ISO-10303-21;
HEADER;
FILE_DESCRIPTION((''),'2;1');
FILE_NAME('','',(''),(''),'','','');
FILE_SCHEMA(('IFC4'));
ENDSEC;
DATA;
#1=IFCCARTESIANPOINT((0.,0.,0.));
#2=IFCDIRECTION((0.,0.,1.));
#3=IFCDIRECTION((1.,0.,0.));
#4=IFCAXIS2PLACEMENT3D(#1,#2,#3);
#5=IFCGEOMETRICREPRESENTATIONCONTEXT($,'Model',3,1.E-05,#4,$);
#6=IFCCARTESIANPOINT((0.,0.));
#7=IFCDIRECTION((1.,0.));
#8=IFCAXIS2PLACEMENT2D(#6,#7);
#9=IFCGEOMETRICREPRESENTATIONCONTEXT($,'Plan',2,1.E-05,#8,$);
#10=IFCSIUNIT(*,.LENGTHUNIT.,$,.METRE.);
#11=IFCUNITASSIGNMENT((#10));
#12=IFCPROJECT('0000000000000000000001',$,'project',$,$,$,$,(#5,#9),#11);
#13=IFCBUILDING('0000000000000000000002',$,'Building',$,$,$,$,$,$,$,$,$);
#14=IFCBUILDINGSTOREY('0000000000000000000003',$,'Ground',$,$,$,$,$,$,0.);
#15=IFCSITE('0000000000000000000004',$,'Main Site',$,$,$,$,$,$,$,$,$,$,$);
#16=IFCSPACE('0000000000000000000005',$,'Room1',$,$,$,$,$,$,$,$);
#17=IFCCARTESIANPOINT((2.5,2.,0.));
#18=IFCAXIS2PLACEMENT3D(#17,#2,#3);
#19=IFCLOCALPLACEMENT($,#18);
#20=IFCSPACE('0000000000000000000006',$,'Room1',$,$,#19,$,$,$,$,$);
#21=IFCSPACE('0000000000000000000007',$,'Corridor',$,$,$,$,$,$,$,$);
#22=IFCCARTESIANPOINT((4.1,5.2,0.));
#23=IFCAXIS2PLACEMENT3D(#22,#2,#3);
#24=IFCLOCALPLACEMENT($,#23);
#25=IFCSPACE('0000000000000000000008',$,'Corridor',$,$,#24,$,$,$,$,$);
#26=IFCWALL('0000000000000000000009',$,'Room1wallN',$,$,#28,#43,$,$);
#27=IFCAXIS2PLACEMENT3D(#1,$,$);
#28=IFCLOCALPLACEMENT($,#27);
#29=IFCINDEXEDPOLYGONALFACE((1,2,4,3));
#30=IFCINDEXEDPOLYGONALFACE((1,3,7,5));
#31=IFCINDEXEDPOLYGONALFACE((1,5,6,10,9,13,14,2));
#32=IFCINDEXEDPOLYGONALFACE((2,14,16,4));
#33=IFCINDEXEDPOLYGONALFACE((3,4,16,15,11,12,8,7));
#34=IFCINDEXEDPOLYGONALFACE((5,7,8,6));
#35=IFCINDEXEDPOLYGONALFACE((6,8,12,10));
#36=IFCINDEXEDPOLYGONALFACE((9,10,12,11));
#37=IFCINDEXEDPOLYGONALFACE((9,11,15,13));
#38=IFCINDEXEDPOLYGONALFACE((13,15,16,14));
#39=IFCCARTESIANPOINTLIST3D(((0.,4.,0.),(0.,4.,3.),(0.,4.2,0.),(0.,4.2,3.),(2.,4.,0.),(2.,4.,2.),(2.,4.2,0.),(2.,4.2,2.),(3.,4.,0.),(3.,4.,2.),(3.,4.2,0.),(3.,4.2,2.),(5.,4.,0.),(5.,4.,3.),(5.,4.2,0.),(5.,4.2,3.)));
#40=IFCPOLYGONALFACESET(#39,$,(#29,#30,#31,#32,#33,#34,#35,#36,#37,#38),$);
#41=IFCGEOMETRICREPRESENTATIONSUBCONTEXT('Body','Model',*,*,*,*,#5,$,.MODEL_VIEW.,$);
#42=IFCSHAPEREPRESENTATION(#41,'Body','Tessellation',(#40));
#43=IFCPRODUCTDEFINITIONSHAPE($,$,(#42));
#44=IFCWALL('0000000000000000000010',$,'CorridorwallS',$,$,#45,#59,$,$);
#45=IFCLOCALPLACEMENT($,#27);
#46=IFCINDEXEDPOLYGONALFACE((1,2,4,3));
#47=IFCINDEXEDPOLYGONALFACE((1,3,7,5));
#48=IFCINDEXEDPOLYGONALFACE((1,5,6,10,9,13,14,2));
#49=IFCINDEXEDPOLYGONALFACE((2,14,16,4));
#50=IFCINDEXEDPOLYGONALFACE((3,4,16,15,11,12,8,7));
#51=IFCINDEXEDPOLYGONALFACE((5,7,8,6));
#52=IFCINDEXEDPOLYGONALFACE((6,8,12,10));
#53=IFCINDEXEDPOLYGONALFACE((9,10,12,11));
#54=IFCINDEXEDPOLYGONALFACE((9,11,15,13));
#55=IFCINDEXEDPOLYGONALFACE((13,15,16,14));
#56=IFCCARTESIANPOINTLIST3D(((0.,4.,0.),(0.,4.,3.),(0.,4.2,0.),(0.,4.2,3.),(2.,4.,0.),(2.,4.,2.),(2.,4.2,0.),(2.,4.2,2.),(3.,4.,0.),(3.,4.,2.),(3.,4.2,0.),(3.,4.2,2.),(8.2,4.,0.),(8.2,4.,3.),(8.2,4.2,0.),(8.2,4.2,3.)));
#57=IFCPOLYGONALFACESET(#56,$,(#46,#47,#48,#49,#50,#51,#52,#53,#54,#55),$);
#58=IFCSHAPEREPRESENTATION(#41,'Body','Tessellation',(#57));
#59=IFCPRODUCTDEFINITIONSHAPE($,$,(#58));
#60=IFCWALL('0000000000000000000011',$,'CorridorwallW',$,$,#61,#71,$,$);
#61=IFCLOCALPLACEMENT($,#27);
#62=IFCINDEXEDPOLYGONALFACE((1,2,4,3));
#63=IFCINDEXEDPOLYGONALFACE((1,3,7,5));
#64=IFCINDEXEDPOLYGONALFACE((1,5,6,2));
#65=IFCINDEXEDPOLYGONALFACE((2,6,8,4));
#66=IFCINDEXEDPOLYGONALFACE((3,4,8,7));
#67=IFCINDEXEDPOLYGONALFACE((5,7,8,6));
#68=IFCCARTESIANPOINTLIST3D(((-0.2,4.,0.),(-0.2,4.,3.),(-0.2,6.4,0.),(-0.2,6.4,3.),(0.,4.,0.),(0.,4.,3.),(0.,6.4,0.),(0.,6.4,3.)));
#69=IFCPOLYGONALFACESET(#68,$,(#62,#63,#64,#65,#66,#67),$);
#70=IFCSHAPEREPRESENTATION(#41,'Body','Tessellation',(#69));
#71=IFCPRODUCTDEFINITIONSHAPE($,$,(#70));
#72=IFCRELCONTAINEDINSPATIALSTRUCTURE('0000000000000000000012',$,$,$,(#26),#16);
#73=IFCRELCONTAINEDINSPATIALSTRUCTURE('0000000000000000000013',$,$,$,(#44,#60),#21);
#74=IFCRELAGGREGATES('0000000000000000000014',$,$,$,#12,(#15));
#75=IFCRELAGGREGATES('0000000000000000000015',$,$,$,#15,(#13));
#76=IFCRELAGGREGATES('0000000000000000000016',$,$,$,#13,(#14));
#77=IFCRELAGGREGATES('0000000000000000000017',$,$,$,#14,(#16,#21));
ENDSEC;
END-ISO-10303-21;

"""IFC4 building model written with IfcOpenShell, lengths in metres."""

from ifc_helpers import new_model, si_unit, frame, origin_with_axes, origin_2d_with_axis, place, context, subcontext, project, spatial, indexed_curve, outline, extrude, element, save


model = new_model("IFC4")

# Units and contexts
model_context = context("Model", 3, precision=1e-05, world=origin_with_axes())
plan_context = context("Plan", 2, precision=1e-05, world=origin_2d_with_axis())
body_context = subcontext(model_context, "Body", "Model", "MODEL_VIEW")
ifc_project = project(units=[si_unit("LENGTHUNIT", "METRE")], contexts=[model_context, plan_context])

# Site, building, storey, space
site = spatial("IfcSite", under=ifc_project, Name="Main Site")
building = spatial("IfcBuilding", under=site, Name="Building")
storey = spatial("IfcBuildingStorey", under=building, Name="Ground", Elevation=0.0)
space_1 = spatial("IfcSpace", under=storey, Name="Room1")

# Wall
wall_1_placement = place(None, frame((0.0, 4.0, 0.0), z_axis=(0.0, 0.0, 1.0), x_axis=(1.0, 0.0, 0.0)))
wall_1 = element("IfcWall", 1, at=wall_1_placement, inside=space_1, Name="Room1wallN", context=body_context, shape_type="SweptSolid", body=[
    extrude(outline(indexed_curve([(0.0, 0.0), (0.0, 0.2), (5.0, 0.2), (5.0, 0.0), (0.0, 0.0)], self_intersect=False)), origin_with_axes(), (0.0, 0.0, 1.0), 3.0),
])

# Shared definitions
space_2_placement = place(None, frame((2.5, 2.0, 0.0), z_axis=(0.0, 0.0, 1.0), x_axis=(1.0, 0.0, 0.0)))
space_2 = spatial("IfcSpace", at=space_2_placement, Name="Room1")

# Opening
opening_1_placement = place(wall_1_placement, frame((2.0, 0.0, 0.0), z_axis=(0.0, 0.0, 1.0), x_axis=(1.0, 0.0, 0.0)))
element("IfcOpeningElement", 2, at=opening_1_placement, inside=space_2, cuts=wall_1, context=body_context, shape_type="SweptSolid", body=[
    extrude(outline(indexed_curve([(0.0, 0.0), (0.0, 0.4), (1.0, 0.4), (1.0, 0.0), (0.0, 0.0)], self_intersect=False)), origin_with_axes(), (0.0, 0.0, 1.0), 2.0),
])

# Shared definitions
space_3 = spatial("IfcSpace", under=storey, Name="Corridor")

# Wall
wall_2_placement = place(None, frame((0.0, 4.0, 0.0), z_axis=(0.0, 0.0, 1.0), x_axis=(1.0, 0.0, 0.0)))
wall_2 = element("IfcWall", 3, at=wall_2_placement, inside=space_3, Name="CorridorwallS", context=body_context, shape_type="SweptSolid", body=[
    extrude(outline(indexed_curve([(0.0, 0.0), (0.0, 0.2), (8.2, 0.2), (8.2, 0.0), (0.0, 0.0)], self_intersect=False)), origin_with_axes(), (0.0, 0.0, 1.0), 3.0),
])

# Shared definitions
space_4_placement = place(None, frame((4.1, 5.2, 0.0), z_axis=(0.0, 0.0, 1.0), x_axis=(1.0, 0.0, 0.0)))
space_4 = spatial("IfcSpace", at=space_4_placement, Name="Corridor")

# Opening
opening_2_placement = place(wall_2_placement, frame((2.0, 0.0, 0.0), z_axis=(0.0, 0.0, 1.0), x_axis=(1.0, 0.0, 0.0)))
element("IfcOpeningElement", 4, at=opening_2_placement, inside=space_4, cuts=wall_2, context=body_context, shape_type="SweptSolid", body=[
    extrude(outline(indexed_curve([(0.0, 0.0), (0.0, 0.4), (1.0, 0.4), (1.0, 0.0), (0.0, 0.0)], self_intersect=False)), origin_with_axes(), (0.0, 0.0, 1.0), 2.0),
])

# Wall
wall_3_placement = place(None, frame((0.0, 4.0, 0.0), z_axis=(0.0, 0.0, 1.0), x_axis=(0.0, 1.0, 0.0)))
element("IfcWall", 5, at=wall_3_placement, inside=space_3, Name="CorridorwallW", context=body_context, shape_type="SweptSolid", body=[
    extrude(outline(indexed_curve([(0.0, 0.0), (0.0, 0.2), (2.4, 0.2), (2.4, 0.0), (0.0, 0.0)], self_intersect=False)), origin_with_axes(), (0.0, 0.0, 1.0), 3.0),
])

save(model, "model.ifc")
